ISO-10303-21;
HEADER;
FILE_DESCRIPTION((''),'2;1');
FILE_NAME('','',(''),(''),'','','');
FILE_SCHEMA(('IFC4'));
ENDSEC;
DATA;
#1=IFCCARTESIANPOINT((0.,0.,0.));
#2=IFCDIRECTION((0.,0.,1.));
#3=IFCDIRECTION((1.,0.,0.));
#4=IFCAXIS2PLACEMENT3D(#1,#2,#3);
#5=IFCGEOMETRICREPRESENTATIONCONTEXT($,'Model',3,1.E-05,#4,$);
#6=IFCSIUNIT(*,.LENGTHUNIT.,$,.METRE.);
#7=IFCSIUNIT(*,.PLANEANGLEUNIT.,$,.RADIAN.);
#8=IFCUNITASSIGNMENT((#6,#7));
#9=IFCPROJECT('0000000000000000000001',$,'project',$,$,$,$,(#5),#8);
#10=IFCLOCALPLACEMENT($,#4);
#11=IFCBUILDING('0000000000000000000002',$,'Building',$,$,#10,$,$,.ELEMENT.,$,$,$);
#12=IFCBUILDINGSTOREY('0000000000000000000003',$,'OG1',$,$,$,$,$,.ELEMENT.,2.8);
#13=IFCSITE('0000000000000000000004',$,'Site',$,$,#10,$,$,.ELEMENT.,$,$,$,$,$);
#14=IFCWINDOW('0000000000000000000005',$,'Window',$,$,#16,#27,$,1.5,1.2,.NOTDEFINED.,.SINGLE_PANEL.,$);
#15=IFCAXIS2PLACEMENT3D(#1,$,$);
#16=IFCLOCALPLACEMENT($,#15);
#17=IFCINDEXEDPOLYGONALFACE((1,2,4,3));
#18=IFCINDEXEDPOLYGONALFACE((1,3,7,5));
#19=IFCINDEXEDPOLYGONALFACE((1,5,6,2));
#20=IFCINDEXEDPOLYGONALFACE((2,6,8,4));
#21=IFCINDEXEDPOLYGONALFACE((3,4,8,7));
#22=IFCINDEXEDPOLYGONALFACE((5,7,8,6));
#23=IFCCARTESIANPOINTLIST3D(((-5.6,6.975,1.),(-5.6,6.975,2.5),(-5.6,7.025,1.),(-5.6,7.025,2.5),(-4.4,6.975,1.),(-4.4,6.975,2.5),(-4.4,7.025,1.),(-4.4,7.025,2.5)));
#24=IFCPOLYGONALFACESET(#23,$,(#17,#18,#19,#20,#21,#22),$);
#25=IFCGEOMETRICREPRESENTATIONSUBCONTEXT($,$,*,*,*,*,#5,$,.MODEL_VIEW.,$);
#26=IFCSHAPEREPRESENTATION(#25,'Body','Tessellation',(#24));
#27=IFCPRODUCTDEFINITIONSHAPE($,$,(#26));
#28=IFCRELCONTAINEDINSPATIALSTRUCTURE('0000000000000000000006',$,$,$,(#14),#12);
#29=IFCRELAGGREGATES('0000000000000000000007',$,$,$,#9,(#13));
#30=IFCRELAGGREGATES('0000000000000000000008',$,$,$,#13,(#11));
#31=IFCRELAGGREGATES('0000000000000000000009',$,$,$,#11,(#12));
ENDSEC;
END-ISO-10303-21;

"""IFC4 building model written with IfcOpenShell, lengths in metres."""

from ifc_helpers import new_model, si_unit, frame, origin, origin_with_axes, origin_2d, place, context, subcontext, project, spatial, rectangle, extrude, element, save


model = new_model("IFC4")

# Units and contexts
model_context = context("Model", 3, precision=1e-05, world=origin_with_axes())
sub_context = subcontext(model_context, None, None, "MODEL_VIEW")
ifc_project = project(units=[si_unit("LENGTHUNIT", "METRE"), si_unit("PLANEANGLEUNIT", "RADIAN")], contexts=[model_context])

# Site, building, storey
placement_1 = place(None, origin_with_axes())
site = spatial("IfcSite", under=ifc_project, at=placement_1, Name="Site", CompositionType="ELEMENT")
building = spatial("IfcBuilding", under=site, at=placement_1, Name="Building", CompositionType="ELEMENT")
storey = spatial("IfcBuildingStorey", under=building, Name="OG1", CompositionType="ELEMENT", Elevation=2.8)

# Window
placement_2 = place(None, origin_with_axes())
window_placement = place(placement_2, frame((-5.0, 7.0, 1.0)))
element("IfcWindow", 1, at=window_placement, inside=storey, Name="Window", OverallHeight=1.5, OverallWidth=1.2, PartitioningType="SINGLE_PANEL", PredefinedType="NOTDEFINED", context=sub_context, shape_type="SweptSolid", body=[
    extrude(rectangle(XDim=1.2, YDim=0.05, at=origin_2d()), origin(), (0.0, 0.0, 1.0), 1.5),
])

save(model, "model.ifc")
